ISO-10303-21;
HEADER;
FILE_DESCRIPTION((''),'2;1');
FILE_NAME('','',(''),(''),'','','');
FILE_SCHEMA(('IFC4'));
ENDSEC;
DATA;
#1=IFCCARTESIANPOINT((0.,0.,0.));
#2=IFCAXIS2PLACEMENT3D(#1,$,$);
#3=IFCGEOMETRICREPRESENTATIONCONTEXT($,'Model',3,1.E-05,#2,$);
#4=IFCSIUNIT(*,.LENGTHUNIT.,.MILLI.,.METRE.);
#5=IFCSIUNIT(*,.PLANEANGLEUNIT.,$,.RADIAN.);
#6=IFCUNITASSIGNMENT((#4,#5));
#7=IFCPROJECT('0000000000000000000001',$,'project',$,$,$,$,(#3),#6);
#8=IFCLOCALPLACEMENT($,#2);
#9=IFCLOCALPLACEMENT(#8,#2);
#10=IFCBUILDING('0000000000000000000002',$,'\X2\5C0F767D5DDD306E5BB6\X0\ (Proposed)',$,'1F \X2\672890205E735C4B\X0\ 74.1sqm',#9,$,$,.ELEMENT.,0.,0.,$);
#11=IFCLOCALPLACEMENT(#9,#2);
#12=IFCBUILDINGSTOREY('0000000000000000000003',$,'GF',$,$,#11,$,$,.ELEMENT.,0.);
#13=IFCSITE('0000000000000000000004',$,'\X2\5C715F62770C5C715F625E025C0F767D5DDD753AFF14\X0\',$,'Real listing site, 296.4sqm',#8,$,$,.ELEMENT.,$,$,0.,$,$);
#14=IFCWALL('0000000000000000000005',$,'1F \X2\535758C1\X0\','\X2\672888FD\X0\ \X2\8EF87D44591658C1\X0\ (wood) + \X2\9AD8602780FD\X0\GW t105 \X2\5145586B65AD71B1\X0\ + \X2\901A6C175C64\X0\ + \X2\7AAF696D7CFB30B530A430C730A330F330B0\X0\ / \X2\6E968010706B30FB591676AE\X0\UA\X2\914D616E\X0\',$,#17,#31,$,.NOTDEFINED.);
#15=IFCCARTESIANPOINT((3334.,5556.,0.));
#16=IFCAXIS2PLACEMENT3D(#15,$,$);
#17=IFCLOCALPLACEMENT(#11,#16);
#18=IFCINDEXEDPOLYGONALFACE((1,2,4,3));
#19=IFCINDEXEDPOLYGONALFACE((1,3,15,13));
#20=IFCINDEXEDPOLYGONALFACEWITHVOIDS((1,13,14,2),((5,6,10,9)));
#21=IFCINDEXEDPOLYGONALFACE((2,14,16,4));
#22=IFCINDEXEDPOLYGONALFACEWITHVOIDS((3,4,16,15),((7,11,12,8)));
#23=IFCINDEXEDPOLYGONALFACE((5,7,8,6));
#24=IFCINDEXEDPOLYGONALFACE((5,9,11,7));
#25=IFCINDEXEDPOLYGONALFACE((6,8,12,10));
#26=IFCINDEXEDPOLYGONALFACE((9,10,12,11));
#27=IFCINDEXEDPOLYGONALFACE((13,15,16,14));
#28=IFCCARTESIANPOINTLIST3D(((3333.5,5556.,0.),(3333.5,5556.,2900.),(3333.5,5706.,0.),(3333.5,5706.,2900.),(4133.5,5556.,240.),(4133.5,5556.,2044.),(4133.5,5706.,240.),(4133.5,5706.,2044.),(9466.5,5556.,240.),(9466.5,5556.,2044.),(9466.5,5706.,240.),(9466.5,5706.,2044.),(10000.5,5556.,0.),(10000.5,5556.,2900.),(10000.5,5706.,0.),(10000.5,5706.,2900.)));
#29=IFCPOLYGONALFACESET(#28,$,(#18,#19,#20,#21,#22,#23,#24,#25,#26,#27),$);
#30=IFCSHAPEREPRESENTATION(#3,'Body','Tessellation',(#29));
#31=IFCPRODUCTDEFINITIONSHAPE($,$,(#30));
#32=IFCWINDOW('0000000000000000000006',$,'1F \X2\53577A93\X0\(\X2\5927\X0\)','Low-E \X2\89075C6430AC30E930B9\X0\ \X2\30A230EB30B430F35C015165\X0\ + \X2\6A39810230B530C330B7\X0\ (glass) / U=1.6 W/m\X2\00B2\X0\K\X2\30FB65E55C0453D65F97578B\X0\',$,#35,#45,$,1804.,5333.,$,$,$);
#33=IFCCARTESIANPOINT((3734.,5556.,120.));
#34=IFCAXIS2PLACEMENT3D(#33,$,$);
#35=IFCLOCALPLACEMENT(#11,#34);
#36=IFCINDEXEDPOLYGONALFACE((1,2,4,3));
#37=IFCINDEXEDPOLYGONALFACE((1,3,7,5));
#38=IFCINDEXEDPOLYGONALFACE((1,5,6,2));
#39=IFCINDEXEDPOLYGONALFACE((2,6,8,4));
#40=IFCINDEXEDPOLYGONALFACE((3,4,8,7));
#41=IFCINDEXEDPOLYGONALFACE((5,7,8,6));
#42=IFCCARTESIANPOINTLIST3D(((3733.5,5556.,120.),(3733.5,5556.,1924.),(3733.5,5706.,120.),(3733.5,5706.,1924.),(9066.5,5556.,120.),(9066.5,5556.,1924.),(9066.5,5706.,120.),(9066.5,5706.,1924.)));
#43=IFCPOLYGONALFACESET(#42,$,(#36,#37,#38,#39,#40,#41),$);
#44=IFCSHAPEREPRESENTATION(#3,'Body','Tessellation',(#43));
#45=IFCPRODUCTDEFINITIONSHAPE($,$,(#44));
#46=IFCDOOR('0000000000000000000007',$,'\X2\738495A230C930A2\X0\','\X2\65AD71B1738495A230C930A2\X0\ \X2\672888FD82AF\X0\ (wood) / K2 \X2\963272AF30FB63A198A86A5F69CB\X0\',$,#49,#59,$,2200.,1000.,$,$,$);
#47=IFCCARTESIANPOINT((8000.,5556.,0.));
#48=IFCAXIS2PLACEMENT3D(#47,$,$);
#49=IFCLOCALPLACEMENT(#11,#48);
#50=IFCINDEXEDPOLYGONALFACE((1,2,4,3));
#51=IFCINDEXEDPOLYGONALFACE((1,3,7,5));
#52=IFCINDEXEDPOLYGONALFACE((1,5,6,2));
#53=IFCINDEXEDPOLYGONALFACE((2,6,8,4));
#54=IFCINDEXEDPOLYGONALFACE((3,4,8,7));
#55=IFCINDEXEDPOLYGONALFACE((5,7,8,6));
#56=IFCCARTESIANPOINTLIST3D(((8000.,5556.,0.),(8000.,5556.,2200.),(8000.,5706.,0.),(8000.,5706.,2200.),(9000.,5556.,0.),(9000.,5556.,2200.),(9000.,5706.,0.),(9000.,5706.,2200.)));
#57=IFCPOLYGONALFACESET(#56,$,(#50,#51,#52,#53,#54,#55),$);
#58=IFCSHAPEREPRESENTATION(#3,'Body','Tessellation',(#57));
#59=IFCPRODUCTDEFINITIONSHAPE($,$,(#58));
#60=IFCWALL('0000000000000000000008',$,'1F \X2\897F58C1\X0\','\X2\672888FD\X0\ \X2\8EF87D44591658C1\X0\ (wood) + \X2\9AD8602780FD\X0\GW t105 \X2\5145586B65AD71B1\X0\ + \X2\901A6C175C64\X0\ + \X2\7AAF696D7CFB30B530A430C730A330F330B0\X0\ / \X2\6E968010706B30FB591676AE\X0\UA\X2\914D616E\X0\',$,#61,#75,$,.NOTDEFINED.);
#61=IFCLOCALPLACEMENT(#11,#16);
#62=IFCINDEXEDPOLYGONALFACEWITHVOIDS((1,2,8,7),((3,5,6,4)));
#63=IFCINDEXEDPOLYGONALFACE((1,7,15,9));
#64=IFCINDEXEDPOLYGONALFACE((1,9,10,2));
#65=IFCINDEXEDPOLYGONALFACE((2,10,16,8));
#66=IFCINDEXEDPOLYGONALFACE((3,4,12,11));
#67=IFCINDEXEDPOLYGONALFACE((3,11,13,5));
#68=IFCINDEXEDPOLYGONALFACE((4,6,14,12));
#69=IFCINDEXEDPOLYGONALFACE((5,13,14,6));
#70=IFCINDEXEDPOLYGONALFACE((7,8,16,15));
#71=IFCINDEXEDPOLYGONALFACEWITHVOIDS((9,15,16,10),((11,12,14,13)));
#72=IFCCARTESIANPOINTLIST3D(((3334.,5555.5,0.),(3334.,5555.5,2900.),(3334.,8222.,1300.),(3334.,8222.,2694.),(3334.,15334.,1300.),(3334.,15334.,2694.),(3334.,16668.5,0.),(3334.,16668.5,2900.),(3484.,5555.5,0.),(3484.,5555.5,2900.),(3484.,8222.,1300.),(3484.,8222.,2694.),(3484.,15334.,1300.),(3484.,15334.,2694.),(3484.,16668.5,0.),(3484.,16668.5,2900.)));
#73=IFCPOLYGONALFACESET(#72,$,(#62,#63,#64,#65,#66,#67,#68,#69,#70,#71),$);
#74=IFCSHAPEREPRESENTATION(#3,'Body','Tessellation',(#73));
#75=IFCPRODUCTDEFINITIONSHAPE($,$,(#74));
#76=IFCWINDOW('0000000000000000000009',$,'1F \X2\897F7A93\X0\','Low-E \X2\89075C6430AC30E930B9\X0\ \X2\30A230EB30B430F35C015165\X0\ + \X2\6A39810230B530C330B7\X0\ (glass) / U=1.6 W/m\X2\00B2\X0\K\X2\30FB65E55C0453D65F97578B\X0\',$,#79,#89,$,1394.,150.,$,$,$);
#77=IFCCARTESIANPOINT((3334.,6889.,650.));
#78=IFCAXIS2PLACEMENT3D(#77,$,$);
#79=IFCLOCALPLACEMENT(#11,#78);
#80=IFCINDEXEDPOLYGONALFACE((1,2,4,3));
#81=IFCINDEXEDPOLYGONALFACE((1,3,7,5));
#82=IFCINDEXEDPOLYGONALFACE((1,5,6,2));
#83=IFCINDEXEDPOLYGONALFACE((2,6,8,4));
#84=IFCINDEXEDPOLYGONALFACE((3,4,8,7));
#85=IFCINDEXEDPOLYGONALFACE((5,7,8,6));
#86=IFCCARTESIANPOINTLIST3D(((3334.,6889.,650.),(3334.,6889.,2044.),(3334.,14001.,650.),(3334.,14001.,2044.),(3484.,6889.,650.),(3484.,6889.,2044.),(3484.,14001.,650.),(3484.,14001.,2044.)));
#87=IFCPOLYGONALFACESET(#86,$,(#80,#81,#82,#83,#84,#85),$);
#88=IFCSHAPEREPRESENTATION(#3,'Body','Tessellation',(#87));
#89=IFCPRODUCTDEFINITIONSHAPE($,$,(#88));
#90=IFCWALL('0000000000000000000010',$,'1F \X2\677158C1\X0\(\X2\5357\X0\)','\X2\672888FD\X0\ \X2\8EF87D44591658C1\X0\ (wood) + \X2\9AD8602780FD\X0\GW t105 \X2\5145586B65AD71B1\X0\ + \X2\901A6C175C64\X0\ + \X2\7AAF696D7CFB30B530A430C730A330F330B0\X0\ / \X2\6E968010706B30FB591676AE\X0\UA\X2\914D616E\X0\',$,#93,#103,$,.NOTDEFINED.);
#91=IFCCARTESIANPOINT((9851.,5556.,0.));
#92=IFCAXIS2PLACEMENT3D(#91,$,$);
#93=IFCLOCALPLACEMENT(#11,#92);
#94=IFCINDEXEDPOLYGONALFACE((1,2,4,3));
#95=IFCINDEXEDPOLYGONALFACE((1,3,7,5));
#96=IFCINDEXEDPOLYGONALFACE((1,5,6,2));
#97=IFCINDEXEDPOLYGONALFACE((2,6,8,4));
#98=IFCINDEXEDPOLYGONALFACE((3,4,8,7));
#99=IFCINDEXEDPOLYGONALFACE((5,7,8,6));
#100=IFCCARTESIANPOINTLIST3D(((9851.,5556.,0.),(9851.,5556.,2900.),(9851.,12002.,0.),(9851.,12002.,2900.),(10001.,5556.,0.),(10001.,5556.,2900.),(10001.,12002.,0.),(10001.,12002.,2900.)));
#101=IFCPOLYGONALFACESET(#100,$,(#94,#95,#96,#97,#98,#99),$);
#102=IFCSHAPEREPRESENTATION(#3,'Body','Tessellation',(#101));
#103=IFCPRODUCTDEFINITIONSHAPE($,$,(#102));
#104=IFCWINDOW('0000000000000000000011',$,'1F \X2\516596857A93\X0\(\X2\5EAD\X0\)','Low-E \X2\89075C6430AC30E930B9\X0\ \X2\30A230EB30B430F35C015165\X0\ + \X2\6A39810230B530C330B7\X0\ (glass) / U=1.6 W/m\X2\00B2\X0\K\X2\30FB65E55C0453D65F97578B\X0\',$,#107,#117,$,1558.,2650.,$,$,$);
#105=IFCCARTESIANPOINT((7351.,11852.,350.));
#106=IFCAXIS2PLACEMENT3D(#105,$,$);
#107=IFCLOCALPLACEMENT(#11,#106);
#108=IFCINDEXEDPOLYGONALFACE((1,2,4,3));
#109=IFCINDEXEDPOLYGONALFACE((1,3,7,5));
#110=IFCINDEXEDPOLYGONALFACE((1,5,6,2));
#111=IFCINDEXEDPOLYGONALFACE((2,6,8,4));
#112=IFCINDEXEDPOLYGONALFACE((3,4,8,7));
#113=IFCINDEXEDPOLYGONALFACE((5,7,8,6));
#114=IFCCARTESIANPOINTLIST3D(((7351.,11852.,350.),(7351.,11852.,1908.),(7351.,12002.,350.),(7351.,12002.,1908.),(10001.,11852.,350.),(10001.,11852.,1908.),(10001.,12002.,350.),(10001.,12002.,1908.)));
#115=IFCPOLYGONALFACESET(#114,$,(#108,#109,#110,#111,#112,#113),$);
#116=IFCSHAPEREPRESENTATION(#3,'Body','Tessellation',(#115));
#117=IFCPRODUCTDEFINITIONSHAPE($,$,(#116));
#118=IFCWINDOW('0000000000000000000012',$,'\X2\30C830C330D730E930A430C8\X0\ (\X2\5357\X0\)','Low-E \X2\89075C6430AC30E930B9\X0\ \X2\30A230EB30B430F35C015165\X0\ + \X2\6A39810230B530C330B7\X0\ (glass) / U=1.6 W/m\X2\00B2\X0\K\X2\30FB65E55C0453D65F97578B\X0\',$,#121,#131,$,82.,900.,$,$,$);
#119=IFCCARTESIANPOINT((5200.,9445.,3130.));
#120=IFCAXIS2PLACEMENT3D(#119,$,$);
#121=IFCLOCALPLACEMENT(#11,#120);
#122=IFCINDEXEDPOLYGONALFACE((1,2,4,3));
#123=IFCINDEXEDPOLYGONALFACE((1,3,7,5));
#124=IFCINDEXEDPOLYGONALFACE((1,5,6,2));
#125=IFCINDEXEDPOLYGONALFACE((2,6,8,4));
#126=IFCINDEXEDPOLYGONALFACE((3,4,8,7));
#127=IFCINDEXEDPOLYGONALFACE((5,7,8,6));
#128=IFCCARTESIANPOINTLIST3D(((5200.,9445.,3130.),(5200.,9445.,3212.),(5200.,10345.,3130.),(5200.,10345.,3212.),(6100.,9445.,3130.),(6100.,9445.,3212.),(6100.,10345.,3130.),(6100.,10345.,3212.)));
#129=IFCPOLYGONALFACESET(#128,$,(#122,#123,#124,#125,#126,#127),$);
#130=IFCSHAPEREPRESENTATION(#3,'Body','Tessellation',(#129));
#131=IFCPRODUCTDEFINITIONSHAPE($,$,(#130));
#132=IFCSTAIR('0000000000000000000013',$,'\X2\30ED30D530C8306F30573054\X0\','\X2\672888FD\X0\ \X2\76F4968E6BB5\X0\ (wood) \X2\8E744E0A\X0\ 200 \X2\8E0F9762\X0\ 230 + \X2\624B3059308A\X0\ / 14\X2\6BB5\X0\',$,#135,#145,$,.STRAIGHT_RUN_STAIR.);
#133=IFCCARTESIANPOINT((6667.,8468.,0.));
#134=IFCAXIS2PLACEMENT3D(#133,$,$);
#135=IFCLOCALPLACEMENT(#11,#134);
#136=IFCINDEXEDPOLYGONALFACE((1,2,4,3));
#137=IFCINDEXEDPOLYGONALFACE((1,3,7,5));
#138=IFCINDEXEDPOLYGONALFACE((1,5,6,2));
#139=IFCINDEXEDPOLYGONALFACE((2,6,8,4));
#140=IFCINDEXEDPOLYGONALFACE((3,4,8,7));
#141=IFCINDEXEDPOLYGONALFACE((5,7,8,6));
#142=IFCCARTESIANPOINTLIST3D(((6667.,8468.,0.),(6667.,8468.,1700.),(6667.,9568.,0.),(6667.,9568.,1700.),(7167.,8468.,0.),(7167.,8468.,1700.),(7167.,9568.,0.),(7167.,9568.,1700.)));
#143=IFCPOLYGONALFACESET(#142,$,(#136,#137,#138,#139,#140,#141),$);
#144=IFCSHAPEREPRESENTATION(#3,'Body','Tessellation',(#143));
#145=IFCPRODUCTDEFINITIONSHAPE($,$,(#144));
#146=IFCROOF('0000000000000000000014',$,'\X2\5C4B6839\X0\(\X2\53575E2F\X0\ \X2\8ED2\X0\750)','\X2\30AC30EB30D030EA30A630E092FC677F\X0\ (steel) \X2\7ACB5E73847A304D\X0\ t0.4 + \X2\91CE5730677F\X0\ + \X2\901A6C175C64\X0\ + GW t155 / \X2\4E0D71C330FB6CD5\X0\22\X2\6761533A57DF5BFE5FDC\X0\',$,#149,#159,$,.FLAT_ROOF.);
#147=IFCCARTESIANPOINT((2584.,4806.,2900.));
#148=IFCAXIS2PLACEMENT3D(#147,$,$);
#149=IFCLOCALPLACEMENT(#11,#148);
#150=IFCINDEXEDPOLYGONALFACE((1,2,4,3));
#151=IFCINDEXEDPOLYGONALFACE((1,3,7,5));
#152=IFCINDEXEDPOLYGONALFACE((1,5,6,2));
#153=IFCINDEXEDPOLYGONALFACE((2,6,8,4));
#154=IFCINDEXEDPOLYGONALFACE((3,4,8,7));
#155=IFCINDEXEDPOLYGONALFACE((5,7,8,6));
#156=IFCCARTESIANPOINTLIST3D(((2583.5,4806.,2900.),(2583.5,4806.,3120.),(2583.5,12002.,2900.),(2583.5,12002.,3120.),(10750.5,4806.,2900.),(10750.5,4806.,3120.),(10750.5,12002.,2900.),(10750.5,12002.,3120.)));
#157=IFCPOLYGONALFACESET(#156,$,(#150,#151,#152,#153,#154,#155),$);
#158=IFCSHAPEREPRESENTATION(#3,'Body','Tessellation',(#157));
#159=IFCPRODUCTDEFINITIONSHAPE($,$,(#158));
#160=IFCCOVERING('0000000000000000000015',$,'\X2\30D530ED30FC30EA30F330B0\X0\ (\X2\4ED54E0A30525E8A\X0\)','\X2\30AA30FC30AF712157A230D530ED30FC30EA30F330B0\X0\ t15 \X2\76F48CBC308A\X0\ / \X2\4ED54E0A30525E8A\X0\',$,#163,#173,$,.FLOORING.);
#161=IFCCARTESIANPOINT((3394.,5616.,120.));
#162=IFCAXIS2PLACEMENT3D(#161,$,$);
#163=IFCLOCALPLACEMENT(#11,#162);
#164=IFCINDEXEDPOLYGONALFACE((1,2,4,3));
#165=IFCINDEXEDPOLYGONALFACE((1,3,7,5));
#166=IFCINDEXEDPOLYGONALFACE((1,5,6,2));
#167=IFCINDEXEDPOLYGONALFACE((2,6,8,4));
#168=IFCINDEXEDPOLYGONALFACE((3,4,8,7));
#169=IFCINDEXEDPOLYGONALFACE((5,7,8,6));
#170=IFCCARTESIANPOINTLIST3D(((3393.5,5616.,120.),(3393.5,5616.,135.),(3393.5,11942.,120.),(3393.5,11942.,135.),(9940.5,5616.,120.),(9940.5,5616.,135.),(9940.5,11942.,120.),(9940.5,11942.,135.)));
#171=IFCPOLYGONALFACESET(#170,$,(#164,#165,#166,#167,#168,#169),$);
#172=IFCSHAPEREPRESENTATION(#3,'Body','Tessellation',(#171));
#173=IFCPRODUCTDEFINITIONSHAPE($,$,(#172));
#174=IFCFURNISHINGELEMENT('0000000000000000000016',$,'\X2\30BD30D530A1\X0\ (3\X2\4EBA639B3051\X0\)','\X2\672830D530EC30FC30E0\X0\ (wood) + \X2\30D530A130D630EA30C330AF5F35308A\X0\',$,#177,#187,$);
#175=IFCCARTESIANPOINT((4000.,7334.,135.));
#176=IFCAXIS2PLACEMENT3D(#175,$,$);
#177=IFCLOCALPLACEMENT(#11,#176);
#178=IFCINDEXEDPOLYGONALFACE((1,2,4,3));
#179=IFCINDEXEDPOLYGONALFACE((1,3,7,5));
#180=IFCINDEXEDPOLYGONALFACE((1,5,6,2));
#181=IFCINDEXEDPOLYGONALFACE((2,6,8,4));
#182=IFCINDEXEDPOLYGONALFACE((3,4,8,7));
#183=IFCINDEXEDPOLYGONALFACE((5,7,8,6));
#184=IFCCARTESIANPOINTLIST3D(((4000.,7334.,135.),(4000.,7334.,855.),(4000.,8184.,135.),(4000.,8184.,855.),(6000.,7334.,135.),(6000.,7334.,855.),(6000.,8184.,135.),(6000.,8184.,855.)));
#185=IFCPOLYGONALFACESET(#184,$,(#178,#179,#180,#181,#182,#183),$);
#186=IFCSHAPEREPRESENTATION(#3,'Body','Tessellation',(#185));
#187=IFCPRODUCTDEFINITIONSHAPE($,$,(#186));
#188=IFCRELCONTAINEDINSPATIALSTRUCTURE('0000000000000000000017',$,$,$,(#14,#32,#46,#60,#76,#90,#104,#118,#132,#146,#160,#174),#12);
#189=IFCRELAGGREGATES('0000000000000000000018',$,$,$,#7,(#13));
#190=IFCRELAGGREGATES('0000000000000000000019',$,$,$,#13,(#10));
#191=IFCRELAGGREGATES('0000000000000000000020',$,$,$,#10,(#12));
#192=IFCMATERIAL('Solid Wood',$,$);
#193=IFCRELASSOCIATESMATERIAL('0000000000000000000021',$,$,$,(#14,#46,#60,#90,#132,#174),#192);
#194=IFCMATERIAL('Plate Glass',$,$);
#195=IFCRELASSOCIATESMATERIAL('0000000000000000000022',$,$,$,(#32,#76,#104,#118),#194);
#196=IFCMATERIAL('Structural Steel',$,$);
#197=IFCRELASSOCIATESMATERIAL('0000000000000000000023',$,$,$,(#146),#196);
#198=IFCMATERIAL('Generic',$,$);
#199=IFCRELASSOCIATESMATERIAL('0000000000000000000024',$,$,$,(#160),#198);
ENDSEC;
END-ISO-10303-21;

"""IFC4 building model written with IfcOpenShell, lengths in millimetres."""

from ifc_helpers import new_model, si_unit, frame, frame_2d, origin, place, context, project, spatial, rectangle, extrude, material, element, fill, save


model = new_model("IFC4")

# Units and contexts
model_context = context("Model", 3, precision=1e-05, world=origin())
ifc_project = project(units=[si_unit("LENGTHUNIT", "METRE", prefix="MILLI"), si_unit("PLANEANGLEUNIT", "RADIAN")], contexts=[model_context])

# Site, building, storey
site_placement = place(None, origin())
site = spatial("IfcSite", under=ifc_project, at=site_placement, Name="山形県山形市小白川町４", ObjectType="Real listing site, 296.4sqm", CompositionType="ELEMENT", RefElevation=0.0)
building_placement = place(site_placement, origin())
building = spatial("IfcBuilding", under=site, at=building_placement, Name="小白川の家 (Proposed)", ObjectType="1F 木造平屋 74.1sqm", CompositionType="ELEMENT", ElevationOfRefHeight=0.0, ElevationOfTerrain=0.0)
storey_placement = place(building_placement, origin())
storey = spatial("IfcBuildingStorey", under=building, at=storey_placement, Name="GF", CompositionType="ELEMENT", Elevation=0.0)

# Shared definitions
ifc_material_1 = material(Name="Solid Wood")

# Wall, openings, window, door
wall_1_placement = place(storey_placement, frame((3334.0, 5556.0, 0.0)))
wall_1 = element("IfcWall", 1, at=wall_1_placement, inside=storey, material=ifc_material_1, Name="1F 南壁", Description="木製 軸組外壁 (wood) + 高性能GW t105 充填断熱 + 通気層 + 窯業系サイディング / 準耐火・外皮UA配慮", PredefinedType="NOTDEFINED", context=model_context, shape_type="SweptSolid", body=[
    extrude(rectangle(XDim=6667.0, YDim=150.0, at=frame_2d((3333.0, 75.0))), frame((3334.0, 5556.0, 0.0)), (0.0, 0.0, 1.0), 2900.0),
])
opening_1_placement = place(storey_placement, frame((3734.0, 5556.0, 120.0)))
opening_1 = element("IfcOpeningElement", 2, at=opening_1_placement, cuts=wall_1, PredefinedType="NOTDEFINED", context=model_context, shape_type="SweptSolid", body=[
    extrude(rectangle(XDim=5333.0, YDim=150.0, at=frame_2d((2666.0, 75.0))), frame((3734.0, 5556.0, 120.0)), (0.0, 0.0, 1.0), 1804.0),
])
opening_2_placement = place(storey_placement, frame((8000.0, 5556.0, 0.0)))
opening_2 = element("IfcOpeningElement", 3, at=opening_2_placement, cuts=wall_1, PredefinedType="NOTDEFINED", context=model_context, shape_type="SweptSolid", body=[
    extrude(rectangle(XDim=1000.0, YDim=150.0, at=frame_2d((500.0, 75.0))), frame((8000.0, 5556.0, 0.0)), (0.0, 0.0, 1.0), 2200.0),
])
ifc_material_2 = material(Name="Plate Glass")
window_1_placement = place(storey_placement, frame((3734.0, 5556.0, 120.0)))
window_1 = element("IfcWindow", 4, at=window_1_placement, inside=storey, material=ifc_material_2, Name="1F 南窓(大)", Description="Low-E 複層ガラス アルゴン封入 + 樹脂サッシ (glass) / U=1.6 W/m²K・日射取得型", OverallHeight=1804.0, OverallWidth=5333.0, context=model_context, shape_type="SweptSolid", body=[
    extrude(rectangle(XDim=5333.0, YDim=150.0, at=frame_2d((2666.0, 75.0))), frame((3734.0, 5556.0, 120.0)), (0.0, 0.0, 1.0), 1804.0),
])
fill(opening_1, window_1)
door_1_placement = place(storey_placement, frame((8000.0, 5556.0, 0.0)))
door_1 = element("IfcDoor", 5, at=door_1_placement, inside=storey, material=ifc_material_1, Name="玄関ドア", Description="断熱玄関ドア 木製芯 (wood) / K2 防犯・採風機構", OverallHeight=2200.0, OverallWidth=1000.0, context=model_context, shape_type="SweptSolid", body=[
    extrude(rectangle(XDim=1000.0, YDim=150.0, at=frame_2d((500.0, 75.0))), frame((8000.0, 5556.0, 0.0)), (0.0, 0.0, 1.0), 2200.0),
])
fill(opening_2, door_1)

# Walls, openings, windows
wall_2_placement = place(storey_placement, frame((3334.0, 5556.0, 0.0)))
wall_2 = element("IfcWall", 6, at=wall_2_placement, inside=storey, material=ifc_material_1, Name="1F 西壁", Description="木製 軸組外壁 (wood) + 高性能GW t105 充填断熱 + 通気層 + 窯業系サイディング / 準耐火・外皮UA配慮", PredefinedType="NOTDEFINED", context=model_context, shape_type="SweptSolid", body=[
    extrude(rectangle(XDim=150.0, YDim=11113.0, at=frame_2d((75.0, 5556.0))), frame((3334.0, 5556.0, 0.0)), (0.0, 0.0, 1.0), 2900.0),
])
opening_3_placement = place(storey_placement, frame((3334.0, 6889.0, 650.0)))
opening_3 = element("IfcOpeningElement", 7, at=opening_3_placement, cuts=wall_2, PredefinedType="NOTDEFINED", context=model_context, shape_type="SweptSolid", body=[
    extrude(rectangle(XDim=150.0, YDim=7112.0, at=frame_2d((75.0, 3556.0))), frame((3334.0, 6889.0, 650.0)), (0.0, 0.0, 1.0), 1394.0),
])
window_2_placement = place(storey_placement, frame((3334.0, 6889.0, 650.0)))
window_2 = element("IfcWindow", 8, at=window_2_placement, inside=storey, material=ifc_material_2, Name="1F 西窓", Description="Low-E 複層ガラス アルゴン封入 + 樹脂サッシ (glass) / U=1.6 W/m²K・日射取得型", OverallHeight=1394.0, OverallWidth=150.0, context=model_context, shape_type="SweptSolid", body=[
    extrude(rectangle(XDim=150.0, YDim=7112.0, at=frame_2d((75.0, 3556.0))), frame((3334.0, 6889.0, 650.0)), (0.0, 0.0, 1.0), 1394.0),
])
fill(opening_3, window_2)
wall_3_placement = place(storey_placement, frame((9851.0, 5556.0, 0.0)))
wall_3 = element("IfcWall", 9, at=wall_3_placement, inside=storey, material=ifc_material_1, Name="1F 東壁(南)", Description="木製 軸組外壁 (wood) + 高性能GW t105 充填断熱 + 通気層 + 窯業系サイディング / 準耐火・外皮UA配慮", PredefinedType="NOTDEFINED", context=model_context, shape_type="SweptSolid", body=[
    extrude(rectangle(XDim=150.0, YDim=6446.0, at=frame_2d((75.0, 3223.0))), frame((9851.0, 5556.0, 0.0)), (0.0, 0.0, 1.0), 2900.0),
])
opening_4_placement = place(storey_placement, frame((7351.0, 11852.0, 350.0)))
opening_4 = element("IfcOpeningElement", 10, at=opening_4_placement, cuts=wall_3, PredefinedType="NOTDEFINED", context=model_context, shape_type="SweptSolid", body=[
    extrude(rectangle(XDim=2650.0, YDim=150.0, at=frame_2d((1325.0, 75.0))), frame((7351.0, 11852.0, 350.0)), (0.0, 0.0, 1.0), 1558.0),
])
window_3_placement = place(storey_placement, frame((7351.0, 11852.0, 350.0)))
window_3 = element("IfcWindow", 11, at=window_3_placement, inside=storey, material=ifc_material_2, Name="1F 入隅窓(庭)", Description="Low-E 複層ガラス アルゴン封入 + 樹脂サッシ (glass) / U=1.6 W/m²K・日射取得型", OverallHeight=1558.0, OverallWidth=2650.0, context=model_context, shape_type="SweptSolid", body=[
    extrude(rectangle(XDim=2650.0, YDim=150.0, at=frame_2d((1325.0, 75.0))), frame((7351.0, 11852.0, 350.0)), (0.0, 0.0, 1.0), 1558.0),
])
fill(opening_4, window_3)

# Window
window_4_placement = place(storey_placement, frame((5200.0, 9445.0, 3130.0)))
element("IfcWindow", 12, at=window_4_placement, inside=storey, material=ifc_material_2, Name="トップライト (南)", Description="Low-E 複層ガラス アルゴン封入 + 樹脂サッシ (glass) / U=1.6 W/m²K・日射取得型", OverallHeight=82.0, OverallWidth=900.0, context=model_context, shape_type="SweptSolid", body=[
    extrude(rectangle(XDim=900.0, YDim=900.0, at=frame_2d((450.0, 450.0))), frame((5200.0, 9445.0, 3130.0)), (0.0, 0.0, 1.0), 82.0),
])

# Stair
stair_placement = place(storey_placement, frame((6667.0, 8468.0, 0.0)))
element("IfcStair", 13, at=stair_placement, inside=storey, material=ifc_material_1, Name="ロフトはしご", Description="木製 直階段 (wood) 蹴上 200 踏面 230 + 手すり / 14段", PredefinedType="STRAIGHT_RUN_STAIR", context=model_context, shape_type="SweptSolid", body=[
    extrude(rectangle(XDim=500.0, YDim=1100.0, at=frame_2d((250.0, 550.0))), frame((6667.0, 8468.0, 0.0)), (0.0, 0.0, 1.0), 1700.0),
])

# Roof
ifc_material_3 = material(Name="Structural Steel")
roof_placement = place(storey_placement, frame((2584.0, 4806.0, 2900.0)))
element("IfcRoof", 14, at=roof_placement, inside=storey, material=ifc_material_3, Name="屋根(南帯 軒750)", Description="ガルバリウム鋼板 (steel) 立平葺き t0.4 + 野地板 + 通気層 + GW t155 / 不燃・法22条区域対応", PredefinedType="FLAT_ROOF", context=model_context, shape_type="SweptSolid", body=[
    extrude(rectangle(XDim=8167.0, YDim=7196.0, at=frame_2d((4083.0, 3598.0))), frame((2584.0, 4806.0, 2900.0)), (0.0, 0.0, 1.0), 220.0),
])

# Covering
ifc_material_4 = material(Name="Generic")
covering_placement = place(storey_placement, frame((3394.0, 5616.0, 120.0)))
element("IfcCovering", 15, at=covering_placement, inside=storey, material=ifc_material_4, Name="フローリング (仕上げ床)", Description="オーク無垢フローリング t15 直貼り / 仕上げ床", PredefinedType="FLOORING", context=model_context, shape_type="SweptSolid", body=[
    extrude(rectangle(XDim=6547.0, YDim=6326.0, at=frame_2d((3273.0, 3163.0))), frame((3394.0, 5616.0, 120.0)), (0.0, 0.0, 1.0), 15.0),
])

# Furnishing element
furnishing_1_placement = place(storey_placement, frame((4000.0, 7334.0, 135.0)))
element("IfcFurnishingElement", 16, at=furnishing_1_placement, inside=storey, material=ifc_material_1, Name="ソファ (3人掛け)", Description="木フレーム (wood) + ファブリック張り", context=model_context, shape_type="SweptSolid", body=[
    extrude(rectangle(XDim=2000.0, YDim=850.0, at=frame_2d((1000.0, 425.0))), frame((4000.0, 7334.0, 135.0)), (0.0, 0.0, 1.0), 720.0),
])

save(model, "model.ifc")
